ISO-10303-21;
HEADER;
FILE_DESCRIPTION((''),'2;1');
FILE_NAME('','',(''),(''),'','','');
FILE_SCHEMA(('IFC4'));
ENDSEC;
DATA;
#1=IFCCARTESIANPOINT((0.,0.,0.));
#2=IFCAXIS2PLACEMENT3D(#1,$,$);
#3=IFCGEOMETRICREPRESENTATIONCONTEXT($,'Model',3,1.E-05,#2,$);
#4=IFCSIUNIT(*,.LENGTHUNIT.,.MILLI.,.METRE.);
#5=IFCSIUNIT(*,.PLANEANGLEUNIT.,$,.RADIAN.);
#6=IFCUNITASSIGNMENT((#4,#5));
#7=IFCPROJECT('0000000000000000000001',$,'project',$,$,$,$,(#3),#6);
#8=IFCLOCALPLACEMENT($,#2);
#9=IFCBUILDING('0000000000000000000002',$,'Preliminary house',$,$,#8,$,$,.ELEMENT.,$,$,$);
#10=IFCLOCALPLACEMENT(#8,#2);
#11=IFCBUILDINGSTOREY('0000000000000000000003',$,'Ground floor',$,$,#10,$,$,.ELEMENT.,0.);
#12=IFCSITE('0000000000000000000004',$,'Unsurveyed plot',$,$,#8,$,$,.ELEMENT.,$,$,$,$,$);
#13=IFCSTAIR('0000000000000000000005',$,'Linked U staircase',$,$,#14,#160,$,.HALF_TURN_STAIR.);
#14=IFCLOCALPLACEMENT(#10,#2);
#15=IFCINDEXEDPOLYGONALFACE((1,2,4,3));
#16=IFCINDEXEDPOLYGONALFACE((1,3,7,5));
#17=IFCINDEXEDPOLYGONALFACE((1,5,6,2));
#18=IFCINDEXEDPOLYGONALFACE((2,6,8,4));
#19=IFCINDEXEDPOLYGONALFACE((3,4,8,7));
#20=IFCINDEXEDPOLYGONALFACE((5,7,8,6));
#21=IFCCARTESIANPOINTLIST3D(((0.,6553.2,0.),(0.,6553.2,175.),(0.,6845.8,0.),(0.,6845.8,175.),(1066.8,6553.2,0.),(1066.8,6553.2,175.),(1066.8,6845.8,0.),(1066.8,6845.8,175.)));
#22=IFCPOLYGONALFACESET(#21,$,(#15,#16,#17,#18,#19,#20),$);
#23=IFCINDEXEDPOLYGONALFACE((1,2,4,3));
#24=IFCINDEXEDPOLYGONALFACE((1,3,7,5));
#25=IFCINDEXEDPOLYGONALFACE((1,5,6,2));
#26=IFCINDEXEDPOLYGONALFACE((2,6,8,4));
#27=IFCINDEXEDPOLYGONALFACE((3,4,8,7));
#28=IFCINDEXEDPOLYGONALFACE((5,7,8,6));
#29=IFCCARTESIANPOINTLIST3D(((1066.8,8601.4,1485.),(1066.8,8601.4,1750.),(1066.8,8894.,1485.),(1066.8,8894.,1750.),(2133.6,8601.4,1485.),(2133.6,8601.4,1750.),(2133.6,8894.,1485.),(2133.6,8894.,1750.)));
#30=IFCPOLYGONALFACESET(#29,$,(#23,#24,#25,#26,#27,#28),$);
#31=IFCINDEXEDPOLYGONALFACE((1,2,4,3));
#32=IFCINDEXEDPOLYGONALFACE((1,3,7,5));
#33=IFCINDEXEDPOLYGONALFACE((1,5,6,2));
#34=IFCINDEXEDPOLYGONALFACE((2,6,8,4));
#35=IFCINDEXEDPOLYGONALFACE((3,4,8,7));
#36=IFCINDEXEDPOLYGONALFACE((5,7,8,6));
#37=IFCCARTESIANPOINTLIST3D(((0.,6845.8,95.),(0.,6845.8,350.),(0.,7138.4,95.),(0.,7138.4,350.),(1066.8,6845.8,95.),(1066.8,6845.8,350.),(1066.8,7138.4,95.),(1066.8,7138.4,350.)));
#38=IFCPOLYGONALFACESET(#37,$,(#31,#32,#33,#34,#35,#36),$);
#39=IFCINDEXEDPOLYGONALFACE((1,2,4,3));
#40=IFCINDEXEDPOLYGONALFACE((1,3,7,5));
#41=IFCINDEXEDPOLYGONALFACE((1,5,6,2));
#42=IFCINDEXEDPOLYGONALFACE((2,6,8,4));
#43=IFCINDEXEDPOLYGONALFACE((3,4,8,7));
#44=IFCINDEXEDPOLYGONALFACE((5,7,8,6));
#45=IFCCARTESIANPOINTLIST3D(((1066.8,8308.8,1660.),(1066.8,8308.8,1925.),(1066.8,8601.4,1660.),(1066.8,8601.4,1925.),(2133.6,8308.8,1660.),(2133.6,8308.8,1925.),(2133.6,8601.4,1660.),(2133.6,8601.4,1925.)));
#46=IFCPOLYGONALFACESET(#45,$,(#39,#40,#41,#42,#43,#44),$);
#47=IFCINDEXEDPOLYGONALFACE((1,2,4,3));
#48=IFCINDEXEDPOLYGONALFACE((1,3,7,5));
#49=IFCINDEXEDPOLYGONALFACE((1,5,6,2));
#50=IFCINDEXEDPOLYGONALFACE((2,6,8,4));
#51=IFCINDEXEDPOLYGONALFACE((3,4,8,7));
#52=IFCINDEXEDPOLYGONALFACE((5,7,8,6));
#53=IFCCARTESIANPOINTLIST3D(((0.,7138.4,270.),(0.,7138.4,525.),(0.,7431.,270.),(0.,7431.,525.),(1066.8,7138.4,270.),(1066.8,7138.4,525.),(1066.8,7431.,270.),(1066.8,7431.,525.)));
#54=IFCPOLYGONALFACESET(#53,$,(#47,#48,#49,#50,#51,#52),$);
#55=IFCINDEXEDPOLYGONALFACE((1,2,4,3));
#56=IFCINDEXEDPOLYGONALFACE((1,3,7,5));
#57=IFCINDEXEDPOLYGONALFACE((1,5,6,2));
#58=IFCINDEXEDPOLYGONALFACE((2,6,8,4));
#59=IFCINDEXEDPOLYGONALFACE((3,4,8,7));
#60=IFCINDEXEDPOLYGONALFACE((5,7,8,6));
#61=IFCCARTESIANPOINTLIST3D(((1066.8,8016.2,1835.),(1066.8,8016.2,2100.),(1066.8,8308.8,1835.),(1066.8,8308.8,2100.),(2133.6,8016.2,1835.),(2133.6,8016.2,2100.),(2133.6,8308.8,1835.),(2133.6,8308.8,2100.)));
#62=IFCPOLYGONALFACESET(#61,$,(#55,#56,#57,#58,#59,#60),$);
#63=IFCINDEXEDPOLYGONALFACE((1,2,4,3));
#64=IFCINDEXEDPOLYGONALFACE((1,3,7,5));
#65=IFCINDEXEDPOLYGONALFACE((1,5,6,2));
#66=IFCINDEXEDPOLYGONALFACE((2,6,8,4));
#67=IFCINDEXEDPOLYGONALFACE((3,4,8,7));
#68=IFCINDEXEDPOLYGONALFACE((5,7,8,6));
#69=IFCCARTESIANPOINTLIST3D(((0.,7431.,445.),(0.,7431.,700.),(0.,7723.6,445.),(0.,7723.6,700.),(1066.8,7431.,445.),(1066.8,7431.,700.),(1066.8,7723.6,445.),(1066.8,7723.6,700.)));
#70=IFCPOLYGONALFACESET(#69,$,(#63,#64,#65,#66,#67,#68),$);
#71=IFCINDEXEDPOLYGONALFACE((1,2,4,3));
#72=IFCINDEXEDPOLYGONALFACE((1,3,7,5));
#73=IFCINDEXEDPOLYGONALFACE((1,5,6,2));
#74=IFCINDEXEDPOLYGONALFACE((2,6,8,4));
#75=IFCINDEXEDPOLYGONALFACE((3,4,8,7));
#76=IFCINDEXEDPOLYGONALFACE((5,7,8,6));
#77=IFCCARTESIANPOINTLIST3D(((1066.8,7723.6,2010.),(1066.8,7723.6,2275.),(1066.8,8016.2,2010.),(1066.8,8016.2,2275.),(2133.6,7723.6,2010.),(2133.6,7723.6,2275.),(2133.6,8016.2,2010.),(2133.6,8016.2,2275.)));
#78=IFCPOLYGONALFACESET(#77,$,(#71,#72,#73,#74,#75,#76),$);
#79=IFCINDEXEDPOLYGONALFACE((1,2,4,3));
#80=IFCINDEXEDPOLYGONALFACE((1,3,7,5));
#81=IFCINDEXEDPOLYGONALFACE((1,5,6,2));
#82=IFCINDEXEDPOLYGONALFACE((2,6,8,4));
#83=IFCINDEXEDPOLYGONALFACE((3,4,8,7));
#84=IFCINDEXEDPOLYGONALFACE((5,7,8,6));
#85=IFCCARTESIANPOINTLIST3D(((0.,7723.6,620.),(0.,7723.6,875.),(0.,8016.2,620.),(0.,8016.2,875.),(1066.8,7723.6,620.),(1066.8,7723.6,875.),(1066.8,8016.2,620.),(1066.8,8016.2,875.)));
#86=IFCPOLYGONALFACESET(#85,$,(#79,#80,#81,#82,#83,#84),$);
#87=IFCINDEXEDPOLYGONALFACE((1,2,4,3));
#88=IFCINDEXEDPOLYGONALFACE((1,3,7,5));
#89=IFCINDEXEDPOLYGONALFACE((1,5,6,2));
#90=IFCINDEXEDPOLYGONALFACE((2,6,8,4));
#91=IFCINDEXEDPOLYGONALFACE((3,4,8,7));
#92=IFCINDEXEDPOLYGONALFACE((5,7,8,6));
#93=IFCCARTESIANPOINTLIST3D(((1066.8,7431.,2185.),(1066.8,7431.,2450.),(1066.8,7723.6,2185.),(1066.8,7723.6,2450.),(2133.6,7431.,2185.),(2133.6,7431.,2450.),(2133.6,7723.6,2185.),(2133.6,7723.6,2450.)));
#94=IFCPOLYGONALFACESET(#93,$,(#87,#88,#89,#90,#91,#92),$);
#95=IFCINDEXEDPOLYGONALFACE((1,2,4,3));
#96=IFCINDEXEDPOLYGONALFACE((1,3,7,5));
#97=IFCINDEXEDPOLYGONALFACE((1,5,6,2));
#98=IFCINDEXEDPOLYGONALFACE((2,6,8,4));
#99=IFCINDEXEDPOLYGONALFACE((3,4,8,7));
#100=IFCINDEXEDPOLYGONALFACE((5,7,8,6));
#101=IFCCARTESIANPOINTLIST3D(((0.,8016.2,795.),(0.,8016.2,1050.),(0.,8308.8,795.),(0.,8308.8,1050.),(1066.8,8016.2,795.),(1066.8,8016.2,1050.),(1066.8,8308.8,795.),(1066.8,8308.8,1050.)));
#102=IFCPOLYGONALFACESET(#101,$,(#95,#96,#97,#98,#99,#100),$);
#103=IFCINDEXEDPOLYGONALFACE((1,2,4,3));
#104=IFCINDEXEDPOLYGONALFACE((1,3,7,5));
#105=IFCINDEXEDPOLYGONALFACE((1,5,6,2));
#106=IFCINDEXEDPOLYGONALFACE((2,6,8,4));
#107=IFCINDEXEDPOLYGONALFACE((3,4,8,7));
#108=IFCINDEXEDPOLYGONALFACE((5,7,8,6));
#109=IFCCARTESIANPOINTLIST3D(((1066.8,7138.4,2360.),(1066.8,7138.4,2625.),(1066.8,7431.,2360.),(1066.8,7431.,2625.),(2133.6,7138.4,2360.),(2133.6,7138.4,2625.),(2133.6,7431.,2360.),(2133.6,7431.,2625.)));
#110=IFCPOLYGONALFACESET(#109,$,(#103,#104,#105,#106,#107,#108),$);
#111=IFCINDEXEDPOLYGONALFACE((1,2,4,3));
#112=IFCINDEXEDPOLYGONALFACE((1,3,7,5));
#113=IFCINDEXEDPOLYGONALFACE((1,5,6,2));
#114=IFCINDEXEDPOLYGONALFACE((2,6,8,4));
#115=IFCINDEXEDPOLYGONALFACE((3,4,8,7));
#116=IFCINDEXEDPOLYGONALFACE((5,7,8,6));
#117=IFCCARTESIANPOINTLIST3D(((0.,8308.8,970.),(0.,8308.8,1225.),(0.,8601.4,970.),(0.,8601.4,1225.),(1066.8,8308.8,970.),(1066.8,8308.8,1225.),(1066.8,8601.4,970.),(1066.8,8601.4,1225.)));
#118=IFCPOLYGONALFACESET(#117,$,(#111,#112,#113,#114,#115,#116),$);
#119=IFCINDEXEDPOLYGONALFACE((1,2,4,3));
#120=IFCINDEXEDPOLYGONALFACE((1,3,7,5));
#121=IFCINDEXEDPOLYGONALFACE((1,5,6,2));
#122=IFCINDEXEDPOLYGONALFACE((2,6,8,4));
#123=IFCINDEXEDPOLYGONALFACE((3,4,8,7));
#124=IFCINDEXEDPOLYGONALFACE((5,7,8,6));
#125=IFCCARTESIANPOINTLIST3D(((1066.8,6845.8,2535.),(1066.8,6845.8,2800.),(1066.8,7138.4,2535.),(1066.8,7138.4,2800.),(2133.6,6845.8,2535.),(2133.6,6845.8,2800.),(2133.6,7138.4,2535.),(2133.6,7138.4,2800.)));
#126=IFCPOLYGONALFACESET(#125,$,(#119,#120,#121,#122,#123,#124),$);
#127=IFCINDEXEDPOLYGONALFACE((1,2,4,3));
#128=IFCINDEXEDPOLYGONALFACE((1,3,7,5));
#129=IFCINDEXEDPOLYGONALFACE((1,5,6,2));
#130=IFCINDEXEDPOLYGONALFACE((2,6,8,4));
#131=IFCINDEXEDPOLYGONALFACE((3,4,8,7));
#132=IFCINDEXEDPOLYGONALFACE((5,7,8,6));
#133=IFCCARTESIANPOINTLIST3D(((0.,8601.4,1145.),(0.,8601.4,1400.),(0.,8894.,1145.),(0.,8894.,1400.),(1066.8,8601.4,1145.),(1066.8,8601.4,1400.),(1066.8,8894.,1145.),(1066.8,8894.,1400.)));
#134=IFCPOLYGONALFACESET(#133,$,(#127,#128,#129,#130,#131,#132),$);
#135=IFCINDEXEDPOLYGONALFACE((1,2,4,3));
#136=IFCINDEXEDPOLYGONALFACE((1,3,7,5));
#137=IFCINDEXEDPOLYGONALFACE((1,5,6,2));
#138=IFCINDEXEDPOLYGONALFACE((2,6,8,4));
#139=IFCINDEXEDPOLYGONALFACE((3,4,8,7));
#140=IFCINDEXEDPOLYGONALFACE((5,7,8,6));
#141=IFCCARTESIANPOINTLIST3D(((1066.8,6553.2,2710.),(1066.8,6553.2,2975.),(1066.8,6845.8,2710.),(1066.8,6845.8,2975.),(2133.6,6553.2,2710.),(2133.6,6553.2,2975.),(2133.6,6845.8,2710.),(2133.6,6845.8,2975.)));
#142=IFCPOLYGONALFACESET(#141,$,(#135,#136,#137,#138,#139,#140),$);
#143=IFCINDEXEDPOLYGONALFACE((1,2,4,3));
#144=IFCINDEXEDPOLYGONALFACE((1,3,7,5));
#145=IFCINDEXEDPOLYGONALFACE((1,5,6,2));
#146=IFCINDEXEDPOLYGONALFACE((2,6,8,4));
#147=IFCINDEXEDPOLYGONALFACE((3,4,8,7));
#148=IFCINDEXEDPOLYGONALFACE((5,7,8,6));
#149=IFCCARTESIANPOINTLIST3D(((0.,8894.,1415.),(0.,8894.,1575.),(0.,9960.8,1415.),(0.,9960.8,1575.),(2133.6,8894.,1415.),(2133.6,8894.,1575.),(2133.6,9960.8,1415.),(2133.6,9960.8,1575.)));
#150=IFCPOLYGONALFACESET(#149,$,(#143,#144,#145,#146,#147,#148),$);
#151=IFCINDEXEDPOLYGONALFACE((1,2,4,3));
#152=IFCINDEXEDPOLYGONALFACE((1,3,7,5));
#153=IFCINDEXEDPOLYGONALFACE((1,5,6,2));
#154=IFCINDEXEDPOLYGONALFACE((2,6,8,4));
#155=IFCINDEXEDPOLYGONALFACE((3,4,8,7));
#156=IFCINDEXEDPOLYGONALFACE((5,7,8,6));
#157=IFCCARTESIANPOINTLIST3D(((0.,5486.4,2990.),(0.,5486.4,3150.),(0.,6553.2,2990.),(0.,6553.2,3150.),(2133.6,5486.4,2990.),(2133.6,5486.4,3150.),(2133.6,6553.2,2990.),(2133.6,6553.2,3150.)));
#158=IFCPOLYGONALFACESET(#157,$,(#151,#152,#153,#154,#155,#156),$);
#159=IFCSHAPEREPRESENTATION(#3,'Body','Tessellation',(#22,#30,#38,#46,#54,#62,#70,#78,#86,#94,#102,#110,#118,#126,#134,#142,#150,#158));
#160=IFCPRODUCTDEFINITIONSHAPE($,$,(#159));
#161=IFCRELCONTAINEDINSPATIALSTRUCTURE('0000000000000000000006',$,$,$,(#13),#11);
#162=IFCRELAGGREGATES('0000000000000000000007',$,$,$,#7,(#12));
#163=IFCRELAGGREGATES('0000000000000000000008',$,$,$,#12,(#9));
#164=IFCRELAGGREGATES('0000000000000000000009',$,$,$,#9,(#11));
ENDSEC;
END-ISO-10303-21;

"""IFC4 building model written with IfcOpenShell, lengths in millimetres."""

from ifc_helpers import new_model, si_unit, frame, origin, place, context, project, spatial, polyline, outline, extrude, element, save


model = new_model("IFC4")

# Units and contexts
model_context = context("Model", 3, precision=1e-05, world=origin())
ifc_project = project(units=[si_unit("LENGTHUNIT", "METRE", prefix="MILLI"), si_unit("PLANEANGLEUNIT", "RADIAN")], contexts=[model_context])

# Site, building, storey
placement_1 = place(None, origin())
site = spatial("IfcSite", under=ifc_project, at=placement_1, Name="Unsurveyed plot", CompositionType="ELEMENT")
building = spatial("IfcBuilding", under=site, at=placement_1, Name="Preliminary house", CompositionType="ELEMENT")
placement_2 = place(placement_1, origin())
storey = spatial("IfcBuildingStorey", under=building, at=placement_2, Name="Ground floor", CompositionType="ELEMENT", Elevation=0.0)

# Stair
element("IfcStair", 1, at=placement_2, inside=storey, Name="Linked U staircase", PredefinedType="HALF_TURN_STAIR", context=model_context, shape_type="SweptSolid", body=[
    extrude(outline(polyline([(1066.8, 6553.2), (1066.8, 6845.8), (0.0, 6845.8), (0.0, 6553.2), (1066.8, 6553.2)])), origin(), (0.0, 0.0, 1.0), 175.0),
    extrude(outline(polyline([(2133.6, 8601.4), (2133.6, 8894.0), (1066.8, 8894.0), (1066.8, 8601.4), (2133.6, 8601.4)])), frame((0.0, 0.0, 1485.0)), (0.0, 0.0, 1.0), 265.0),
    extrude(outline(polyline([(1066.8, 6845.8), (1066.8, 7138.4), (0.0, 7138.4), (0.0, 6845.8), (1066.8, 6845.8)])), frame((0.0, 0.0, 95.0)), (0.0, 0.0, 1.0), 255.0),
    extrude(outline(polyline([(2133.6, 8308.8), (2133.6, 8601.4), (1066.8, 8601.4), (1066.8, 8308.8), (2133.6, 8308.8)])), frame((0.0, 0.0, 1660.0)), (0.0, 0.0, 1.0), 265.0),
    extrude(outline(polyline([(1066.8, 7138.4), (1066.8, 7431.0), (0.0, 7431.0), (0.0, 7138.4), (1066.8, 7138.4)])), frame((0.0, 0.0, 270.0)), (0.0, 0.0, 1.0), 255.0),
    extrude(outline(polyline([(2133.6, 8016.2), (2133.6, 8308.8), (1066.8, 8308.8), (1066.8, 8016.2), (2133.6, 8016.2)])), frame((0.0, 0.0, 1835.0)), (0.0, 0.0, 1.0), 265.0),
    extrude(outline(polyline([(1066.8, 7431.0), (1066.8, 7723.6), (0.0, 7723.6), (0.0, 7431.0), (1066.8, 7431.0)])), frame((0.0, 0.0, 445.0)), (0.0, 0.0, 1.0), 255.0),
    extrude(outline(polyline([(2133.6, 7723.6), (2133.6, 8016.2), (1066.8, 8016.2), (1066.8, 7723.6), (2133.6, 7723.6)])), frame((0.0, 0.0, 2010.0)), (0.0, 0.0, 1.0), 265.0),
    extrude(outline(polyline([(1066.8, 7723.6), (1066.8, 8016.2), (0.0, 8016.2), (0.0, 7723.6), (1066.8, 7723.6)])), frame((0.0, 0.0, 620.0)), (0.0, 0.0, 1.0), 255.0),
    extrude(outline(polyline([(2133.6, 7431.0), (2133.6, 7723.6), (1066.8, 7723.6), (1066.8, 7431.0), (2133.6, 7431.0)])), frame((0.0, 0.0, 2185.0)), (0.0, 0.0, 1.0), 265.0),
    extrude(outline(polyline([(1066.8, 8016.2), (1066.8, 8308.8), (0.0, 8308.8), (0.0, 8016.2), (1066.8, 8016.2)])), frame((0.0, 0.0, 795.0)), (0.0, 0.0, 1.0), 255.0),
    extrude(outline(polyline([(2133.6, 7138.4), (2133.6, 7431.0), (1066.8, 7431.0), (1066.8, 7138.4), (2133.6, 7138.4)])), frame((0.0, 0.0, 2360.0)), (0.0, 0.0, 1.0), 265.0),
    extrude(outline(polyline([(1066.8, 8308.8), (1066.8, 8601.4), (0.0, 8601.4), (0.0, 8308.8), (1066.8, 8308.8)])), frame((0.0, 0.0, 970.0)), (0.0, 0.0, 1.0), 255.0),
    extrude(outline(polyline([(2133.6, 6845.8), (2133.6, 7138.4), (1066.8, 7138.4), (1066.8, 6845.8), (2133.6, 6845.8)])), frame((0.0, 0.0, 2535.0)), (0.0, 0.0, 1.0), 265.0),
    extrude(outline(polyline([(1066.8, 8601.4), (1066.8, 8894.0), (0.0, 8894.0), (0.0, 8601.4), (1066.8, 8601.4)])), frame((0.0, 0.0, 1145.0)), (0.0, 0.0, 1.0), 255.0),
    extrude(outline(polyline([(2133.6, 6553.2), (2133.6, 6845.8), (1066.8, 6845.8), (1066.8, 6553.2), (2133.6, 6553.2)])), frame((0.0, 0.0, 2710.0)), (0.0, 0.0, 1.0), 265.0),
    extrude(outline(polyline([(2133.6, 8894.0), (2133.6, 9960.8), (0.0, 9960.8), (0.0, 8894.0), (2133.6, 8894.0)])), frame((0.0, 0.0, 1415.0)), (0.0, 0.0, 1.0), 160.0),
    extrude(outline(polyline([(2133.6, 5486.4), (2133.6, 6553.2), (0.0, 6553.2), (0.0, 5486.4), (2133.6, 5486.4)])), frame((0.0, 0.0, 2990.0)), (0.0, 0.0, 1.0), 160.0),
])

save(model, "model.ifc")
